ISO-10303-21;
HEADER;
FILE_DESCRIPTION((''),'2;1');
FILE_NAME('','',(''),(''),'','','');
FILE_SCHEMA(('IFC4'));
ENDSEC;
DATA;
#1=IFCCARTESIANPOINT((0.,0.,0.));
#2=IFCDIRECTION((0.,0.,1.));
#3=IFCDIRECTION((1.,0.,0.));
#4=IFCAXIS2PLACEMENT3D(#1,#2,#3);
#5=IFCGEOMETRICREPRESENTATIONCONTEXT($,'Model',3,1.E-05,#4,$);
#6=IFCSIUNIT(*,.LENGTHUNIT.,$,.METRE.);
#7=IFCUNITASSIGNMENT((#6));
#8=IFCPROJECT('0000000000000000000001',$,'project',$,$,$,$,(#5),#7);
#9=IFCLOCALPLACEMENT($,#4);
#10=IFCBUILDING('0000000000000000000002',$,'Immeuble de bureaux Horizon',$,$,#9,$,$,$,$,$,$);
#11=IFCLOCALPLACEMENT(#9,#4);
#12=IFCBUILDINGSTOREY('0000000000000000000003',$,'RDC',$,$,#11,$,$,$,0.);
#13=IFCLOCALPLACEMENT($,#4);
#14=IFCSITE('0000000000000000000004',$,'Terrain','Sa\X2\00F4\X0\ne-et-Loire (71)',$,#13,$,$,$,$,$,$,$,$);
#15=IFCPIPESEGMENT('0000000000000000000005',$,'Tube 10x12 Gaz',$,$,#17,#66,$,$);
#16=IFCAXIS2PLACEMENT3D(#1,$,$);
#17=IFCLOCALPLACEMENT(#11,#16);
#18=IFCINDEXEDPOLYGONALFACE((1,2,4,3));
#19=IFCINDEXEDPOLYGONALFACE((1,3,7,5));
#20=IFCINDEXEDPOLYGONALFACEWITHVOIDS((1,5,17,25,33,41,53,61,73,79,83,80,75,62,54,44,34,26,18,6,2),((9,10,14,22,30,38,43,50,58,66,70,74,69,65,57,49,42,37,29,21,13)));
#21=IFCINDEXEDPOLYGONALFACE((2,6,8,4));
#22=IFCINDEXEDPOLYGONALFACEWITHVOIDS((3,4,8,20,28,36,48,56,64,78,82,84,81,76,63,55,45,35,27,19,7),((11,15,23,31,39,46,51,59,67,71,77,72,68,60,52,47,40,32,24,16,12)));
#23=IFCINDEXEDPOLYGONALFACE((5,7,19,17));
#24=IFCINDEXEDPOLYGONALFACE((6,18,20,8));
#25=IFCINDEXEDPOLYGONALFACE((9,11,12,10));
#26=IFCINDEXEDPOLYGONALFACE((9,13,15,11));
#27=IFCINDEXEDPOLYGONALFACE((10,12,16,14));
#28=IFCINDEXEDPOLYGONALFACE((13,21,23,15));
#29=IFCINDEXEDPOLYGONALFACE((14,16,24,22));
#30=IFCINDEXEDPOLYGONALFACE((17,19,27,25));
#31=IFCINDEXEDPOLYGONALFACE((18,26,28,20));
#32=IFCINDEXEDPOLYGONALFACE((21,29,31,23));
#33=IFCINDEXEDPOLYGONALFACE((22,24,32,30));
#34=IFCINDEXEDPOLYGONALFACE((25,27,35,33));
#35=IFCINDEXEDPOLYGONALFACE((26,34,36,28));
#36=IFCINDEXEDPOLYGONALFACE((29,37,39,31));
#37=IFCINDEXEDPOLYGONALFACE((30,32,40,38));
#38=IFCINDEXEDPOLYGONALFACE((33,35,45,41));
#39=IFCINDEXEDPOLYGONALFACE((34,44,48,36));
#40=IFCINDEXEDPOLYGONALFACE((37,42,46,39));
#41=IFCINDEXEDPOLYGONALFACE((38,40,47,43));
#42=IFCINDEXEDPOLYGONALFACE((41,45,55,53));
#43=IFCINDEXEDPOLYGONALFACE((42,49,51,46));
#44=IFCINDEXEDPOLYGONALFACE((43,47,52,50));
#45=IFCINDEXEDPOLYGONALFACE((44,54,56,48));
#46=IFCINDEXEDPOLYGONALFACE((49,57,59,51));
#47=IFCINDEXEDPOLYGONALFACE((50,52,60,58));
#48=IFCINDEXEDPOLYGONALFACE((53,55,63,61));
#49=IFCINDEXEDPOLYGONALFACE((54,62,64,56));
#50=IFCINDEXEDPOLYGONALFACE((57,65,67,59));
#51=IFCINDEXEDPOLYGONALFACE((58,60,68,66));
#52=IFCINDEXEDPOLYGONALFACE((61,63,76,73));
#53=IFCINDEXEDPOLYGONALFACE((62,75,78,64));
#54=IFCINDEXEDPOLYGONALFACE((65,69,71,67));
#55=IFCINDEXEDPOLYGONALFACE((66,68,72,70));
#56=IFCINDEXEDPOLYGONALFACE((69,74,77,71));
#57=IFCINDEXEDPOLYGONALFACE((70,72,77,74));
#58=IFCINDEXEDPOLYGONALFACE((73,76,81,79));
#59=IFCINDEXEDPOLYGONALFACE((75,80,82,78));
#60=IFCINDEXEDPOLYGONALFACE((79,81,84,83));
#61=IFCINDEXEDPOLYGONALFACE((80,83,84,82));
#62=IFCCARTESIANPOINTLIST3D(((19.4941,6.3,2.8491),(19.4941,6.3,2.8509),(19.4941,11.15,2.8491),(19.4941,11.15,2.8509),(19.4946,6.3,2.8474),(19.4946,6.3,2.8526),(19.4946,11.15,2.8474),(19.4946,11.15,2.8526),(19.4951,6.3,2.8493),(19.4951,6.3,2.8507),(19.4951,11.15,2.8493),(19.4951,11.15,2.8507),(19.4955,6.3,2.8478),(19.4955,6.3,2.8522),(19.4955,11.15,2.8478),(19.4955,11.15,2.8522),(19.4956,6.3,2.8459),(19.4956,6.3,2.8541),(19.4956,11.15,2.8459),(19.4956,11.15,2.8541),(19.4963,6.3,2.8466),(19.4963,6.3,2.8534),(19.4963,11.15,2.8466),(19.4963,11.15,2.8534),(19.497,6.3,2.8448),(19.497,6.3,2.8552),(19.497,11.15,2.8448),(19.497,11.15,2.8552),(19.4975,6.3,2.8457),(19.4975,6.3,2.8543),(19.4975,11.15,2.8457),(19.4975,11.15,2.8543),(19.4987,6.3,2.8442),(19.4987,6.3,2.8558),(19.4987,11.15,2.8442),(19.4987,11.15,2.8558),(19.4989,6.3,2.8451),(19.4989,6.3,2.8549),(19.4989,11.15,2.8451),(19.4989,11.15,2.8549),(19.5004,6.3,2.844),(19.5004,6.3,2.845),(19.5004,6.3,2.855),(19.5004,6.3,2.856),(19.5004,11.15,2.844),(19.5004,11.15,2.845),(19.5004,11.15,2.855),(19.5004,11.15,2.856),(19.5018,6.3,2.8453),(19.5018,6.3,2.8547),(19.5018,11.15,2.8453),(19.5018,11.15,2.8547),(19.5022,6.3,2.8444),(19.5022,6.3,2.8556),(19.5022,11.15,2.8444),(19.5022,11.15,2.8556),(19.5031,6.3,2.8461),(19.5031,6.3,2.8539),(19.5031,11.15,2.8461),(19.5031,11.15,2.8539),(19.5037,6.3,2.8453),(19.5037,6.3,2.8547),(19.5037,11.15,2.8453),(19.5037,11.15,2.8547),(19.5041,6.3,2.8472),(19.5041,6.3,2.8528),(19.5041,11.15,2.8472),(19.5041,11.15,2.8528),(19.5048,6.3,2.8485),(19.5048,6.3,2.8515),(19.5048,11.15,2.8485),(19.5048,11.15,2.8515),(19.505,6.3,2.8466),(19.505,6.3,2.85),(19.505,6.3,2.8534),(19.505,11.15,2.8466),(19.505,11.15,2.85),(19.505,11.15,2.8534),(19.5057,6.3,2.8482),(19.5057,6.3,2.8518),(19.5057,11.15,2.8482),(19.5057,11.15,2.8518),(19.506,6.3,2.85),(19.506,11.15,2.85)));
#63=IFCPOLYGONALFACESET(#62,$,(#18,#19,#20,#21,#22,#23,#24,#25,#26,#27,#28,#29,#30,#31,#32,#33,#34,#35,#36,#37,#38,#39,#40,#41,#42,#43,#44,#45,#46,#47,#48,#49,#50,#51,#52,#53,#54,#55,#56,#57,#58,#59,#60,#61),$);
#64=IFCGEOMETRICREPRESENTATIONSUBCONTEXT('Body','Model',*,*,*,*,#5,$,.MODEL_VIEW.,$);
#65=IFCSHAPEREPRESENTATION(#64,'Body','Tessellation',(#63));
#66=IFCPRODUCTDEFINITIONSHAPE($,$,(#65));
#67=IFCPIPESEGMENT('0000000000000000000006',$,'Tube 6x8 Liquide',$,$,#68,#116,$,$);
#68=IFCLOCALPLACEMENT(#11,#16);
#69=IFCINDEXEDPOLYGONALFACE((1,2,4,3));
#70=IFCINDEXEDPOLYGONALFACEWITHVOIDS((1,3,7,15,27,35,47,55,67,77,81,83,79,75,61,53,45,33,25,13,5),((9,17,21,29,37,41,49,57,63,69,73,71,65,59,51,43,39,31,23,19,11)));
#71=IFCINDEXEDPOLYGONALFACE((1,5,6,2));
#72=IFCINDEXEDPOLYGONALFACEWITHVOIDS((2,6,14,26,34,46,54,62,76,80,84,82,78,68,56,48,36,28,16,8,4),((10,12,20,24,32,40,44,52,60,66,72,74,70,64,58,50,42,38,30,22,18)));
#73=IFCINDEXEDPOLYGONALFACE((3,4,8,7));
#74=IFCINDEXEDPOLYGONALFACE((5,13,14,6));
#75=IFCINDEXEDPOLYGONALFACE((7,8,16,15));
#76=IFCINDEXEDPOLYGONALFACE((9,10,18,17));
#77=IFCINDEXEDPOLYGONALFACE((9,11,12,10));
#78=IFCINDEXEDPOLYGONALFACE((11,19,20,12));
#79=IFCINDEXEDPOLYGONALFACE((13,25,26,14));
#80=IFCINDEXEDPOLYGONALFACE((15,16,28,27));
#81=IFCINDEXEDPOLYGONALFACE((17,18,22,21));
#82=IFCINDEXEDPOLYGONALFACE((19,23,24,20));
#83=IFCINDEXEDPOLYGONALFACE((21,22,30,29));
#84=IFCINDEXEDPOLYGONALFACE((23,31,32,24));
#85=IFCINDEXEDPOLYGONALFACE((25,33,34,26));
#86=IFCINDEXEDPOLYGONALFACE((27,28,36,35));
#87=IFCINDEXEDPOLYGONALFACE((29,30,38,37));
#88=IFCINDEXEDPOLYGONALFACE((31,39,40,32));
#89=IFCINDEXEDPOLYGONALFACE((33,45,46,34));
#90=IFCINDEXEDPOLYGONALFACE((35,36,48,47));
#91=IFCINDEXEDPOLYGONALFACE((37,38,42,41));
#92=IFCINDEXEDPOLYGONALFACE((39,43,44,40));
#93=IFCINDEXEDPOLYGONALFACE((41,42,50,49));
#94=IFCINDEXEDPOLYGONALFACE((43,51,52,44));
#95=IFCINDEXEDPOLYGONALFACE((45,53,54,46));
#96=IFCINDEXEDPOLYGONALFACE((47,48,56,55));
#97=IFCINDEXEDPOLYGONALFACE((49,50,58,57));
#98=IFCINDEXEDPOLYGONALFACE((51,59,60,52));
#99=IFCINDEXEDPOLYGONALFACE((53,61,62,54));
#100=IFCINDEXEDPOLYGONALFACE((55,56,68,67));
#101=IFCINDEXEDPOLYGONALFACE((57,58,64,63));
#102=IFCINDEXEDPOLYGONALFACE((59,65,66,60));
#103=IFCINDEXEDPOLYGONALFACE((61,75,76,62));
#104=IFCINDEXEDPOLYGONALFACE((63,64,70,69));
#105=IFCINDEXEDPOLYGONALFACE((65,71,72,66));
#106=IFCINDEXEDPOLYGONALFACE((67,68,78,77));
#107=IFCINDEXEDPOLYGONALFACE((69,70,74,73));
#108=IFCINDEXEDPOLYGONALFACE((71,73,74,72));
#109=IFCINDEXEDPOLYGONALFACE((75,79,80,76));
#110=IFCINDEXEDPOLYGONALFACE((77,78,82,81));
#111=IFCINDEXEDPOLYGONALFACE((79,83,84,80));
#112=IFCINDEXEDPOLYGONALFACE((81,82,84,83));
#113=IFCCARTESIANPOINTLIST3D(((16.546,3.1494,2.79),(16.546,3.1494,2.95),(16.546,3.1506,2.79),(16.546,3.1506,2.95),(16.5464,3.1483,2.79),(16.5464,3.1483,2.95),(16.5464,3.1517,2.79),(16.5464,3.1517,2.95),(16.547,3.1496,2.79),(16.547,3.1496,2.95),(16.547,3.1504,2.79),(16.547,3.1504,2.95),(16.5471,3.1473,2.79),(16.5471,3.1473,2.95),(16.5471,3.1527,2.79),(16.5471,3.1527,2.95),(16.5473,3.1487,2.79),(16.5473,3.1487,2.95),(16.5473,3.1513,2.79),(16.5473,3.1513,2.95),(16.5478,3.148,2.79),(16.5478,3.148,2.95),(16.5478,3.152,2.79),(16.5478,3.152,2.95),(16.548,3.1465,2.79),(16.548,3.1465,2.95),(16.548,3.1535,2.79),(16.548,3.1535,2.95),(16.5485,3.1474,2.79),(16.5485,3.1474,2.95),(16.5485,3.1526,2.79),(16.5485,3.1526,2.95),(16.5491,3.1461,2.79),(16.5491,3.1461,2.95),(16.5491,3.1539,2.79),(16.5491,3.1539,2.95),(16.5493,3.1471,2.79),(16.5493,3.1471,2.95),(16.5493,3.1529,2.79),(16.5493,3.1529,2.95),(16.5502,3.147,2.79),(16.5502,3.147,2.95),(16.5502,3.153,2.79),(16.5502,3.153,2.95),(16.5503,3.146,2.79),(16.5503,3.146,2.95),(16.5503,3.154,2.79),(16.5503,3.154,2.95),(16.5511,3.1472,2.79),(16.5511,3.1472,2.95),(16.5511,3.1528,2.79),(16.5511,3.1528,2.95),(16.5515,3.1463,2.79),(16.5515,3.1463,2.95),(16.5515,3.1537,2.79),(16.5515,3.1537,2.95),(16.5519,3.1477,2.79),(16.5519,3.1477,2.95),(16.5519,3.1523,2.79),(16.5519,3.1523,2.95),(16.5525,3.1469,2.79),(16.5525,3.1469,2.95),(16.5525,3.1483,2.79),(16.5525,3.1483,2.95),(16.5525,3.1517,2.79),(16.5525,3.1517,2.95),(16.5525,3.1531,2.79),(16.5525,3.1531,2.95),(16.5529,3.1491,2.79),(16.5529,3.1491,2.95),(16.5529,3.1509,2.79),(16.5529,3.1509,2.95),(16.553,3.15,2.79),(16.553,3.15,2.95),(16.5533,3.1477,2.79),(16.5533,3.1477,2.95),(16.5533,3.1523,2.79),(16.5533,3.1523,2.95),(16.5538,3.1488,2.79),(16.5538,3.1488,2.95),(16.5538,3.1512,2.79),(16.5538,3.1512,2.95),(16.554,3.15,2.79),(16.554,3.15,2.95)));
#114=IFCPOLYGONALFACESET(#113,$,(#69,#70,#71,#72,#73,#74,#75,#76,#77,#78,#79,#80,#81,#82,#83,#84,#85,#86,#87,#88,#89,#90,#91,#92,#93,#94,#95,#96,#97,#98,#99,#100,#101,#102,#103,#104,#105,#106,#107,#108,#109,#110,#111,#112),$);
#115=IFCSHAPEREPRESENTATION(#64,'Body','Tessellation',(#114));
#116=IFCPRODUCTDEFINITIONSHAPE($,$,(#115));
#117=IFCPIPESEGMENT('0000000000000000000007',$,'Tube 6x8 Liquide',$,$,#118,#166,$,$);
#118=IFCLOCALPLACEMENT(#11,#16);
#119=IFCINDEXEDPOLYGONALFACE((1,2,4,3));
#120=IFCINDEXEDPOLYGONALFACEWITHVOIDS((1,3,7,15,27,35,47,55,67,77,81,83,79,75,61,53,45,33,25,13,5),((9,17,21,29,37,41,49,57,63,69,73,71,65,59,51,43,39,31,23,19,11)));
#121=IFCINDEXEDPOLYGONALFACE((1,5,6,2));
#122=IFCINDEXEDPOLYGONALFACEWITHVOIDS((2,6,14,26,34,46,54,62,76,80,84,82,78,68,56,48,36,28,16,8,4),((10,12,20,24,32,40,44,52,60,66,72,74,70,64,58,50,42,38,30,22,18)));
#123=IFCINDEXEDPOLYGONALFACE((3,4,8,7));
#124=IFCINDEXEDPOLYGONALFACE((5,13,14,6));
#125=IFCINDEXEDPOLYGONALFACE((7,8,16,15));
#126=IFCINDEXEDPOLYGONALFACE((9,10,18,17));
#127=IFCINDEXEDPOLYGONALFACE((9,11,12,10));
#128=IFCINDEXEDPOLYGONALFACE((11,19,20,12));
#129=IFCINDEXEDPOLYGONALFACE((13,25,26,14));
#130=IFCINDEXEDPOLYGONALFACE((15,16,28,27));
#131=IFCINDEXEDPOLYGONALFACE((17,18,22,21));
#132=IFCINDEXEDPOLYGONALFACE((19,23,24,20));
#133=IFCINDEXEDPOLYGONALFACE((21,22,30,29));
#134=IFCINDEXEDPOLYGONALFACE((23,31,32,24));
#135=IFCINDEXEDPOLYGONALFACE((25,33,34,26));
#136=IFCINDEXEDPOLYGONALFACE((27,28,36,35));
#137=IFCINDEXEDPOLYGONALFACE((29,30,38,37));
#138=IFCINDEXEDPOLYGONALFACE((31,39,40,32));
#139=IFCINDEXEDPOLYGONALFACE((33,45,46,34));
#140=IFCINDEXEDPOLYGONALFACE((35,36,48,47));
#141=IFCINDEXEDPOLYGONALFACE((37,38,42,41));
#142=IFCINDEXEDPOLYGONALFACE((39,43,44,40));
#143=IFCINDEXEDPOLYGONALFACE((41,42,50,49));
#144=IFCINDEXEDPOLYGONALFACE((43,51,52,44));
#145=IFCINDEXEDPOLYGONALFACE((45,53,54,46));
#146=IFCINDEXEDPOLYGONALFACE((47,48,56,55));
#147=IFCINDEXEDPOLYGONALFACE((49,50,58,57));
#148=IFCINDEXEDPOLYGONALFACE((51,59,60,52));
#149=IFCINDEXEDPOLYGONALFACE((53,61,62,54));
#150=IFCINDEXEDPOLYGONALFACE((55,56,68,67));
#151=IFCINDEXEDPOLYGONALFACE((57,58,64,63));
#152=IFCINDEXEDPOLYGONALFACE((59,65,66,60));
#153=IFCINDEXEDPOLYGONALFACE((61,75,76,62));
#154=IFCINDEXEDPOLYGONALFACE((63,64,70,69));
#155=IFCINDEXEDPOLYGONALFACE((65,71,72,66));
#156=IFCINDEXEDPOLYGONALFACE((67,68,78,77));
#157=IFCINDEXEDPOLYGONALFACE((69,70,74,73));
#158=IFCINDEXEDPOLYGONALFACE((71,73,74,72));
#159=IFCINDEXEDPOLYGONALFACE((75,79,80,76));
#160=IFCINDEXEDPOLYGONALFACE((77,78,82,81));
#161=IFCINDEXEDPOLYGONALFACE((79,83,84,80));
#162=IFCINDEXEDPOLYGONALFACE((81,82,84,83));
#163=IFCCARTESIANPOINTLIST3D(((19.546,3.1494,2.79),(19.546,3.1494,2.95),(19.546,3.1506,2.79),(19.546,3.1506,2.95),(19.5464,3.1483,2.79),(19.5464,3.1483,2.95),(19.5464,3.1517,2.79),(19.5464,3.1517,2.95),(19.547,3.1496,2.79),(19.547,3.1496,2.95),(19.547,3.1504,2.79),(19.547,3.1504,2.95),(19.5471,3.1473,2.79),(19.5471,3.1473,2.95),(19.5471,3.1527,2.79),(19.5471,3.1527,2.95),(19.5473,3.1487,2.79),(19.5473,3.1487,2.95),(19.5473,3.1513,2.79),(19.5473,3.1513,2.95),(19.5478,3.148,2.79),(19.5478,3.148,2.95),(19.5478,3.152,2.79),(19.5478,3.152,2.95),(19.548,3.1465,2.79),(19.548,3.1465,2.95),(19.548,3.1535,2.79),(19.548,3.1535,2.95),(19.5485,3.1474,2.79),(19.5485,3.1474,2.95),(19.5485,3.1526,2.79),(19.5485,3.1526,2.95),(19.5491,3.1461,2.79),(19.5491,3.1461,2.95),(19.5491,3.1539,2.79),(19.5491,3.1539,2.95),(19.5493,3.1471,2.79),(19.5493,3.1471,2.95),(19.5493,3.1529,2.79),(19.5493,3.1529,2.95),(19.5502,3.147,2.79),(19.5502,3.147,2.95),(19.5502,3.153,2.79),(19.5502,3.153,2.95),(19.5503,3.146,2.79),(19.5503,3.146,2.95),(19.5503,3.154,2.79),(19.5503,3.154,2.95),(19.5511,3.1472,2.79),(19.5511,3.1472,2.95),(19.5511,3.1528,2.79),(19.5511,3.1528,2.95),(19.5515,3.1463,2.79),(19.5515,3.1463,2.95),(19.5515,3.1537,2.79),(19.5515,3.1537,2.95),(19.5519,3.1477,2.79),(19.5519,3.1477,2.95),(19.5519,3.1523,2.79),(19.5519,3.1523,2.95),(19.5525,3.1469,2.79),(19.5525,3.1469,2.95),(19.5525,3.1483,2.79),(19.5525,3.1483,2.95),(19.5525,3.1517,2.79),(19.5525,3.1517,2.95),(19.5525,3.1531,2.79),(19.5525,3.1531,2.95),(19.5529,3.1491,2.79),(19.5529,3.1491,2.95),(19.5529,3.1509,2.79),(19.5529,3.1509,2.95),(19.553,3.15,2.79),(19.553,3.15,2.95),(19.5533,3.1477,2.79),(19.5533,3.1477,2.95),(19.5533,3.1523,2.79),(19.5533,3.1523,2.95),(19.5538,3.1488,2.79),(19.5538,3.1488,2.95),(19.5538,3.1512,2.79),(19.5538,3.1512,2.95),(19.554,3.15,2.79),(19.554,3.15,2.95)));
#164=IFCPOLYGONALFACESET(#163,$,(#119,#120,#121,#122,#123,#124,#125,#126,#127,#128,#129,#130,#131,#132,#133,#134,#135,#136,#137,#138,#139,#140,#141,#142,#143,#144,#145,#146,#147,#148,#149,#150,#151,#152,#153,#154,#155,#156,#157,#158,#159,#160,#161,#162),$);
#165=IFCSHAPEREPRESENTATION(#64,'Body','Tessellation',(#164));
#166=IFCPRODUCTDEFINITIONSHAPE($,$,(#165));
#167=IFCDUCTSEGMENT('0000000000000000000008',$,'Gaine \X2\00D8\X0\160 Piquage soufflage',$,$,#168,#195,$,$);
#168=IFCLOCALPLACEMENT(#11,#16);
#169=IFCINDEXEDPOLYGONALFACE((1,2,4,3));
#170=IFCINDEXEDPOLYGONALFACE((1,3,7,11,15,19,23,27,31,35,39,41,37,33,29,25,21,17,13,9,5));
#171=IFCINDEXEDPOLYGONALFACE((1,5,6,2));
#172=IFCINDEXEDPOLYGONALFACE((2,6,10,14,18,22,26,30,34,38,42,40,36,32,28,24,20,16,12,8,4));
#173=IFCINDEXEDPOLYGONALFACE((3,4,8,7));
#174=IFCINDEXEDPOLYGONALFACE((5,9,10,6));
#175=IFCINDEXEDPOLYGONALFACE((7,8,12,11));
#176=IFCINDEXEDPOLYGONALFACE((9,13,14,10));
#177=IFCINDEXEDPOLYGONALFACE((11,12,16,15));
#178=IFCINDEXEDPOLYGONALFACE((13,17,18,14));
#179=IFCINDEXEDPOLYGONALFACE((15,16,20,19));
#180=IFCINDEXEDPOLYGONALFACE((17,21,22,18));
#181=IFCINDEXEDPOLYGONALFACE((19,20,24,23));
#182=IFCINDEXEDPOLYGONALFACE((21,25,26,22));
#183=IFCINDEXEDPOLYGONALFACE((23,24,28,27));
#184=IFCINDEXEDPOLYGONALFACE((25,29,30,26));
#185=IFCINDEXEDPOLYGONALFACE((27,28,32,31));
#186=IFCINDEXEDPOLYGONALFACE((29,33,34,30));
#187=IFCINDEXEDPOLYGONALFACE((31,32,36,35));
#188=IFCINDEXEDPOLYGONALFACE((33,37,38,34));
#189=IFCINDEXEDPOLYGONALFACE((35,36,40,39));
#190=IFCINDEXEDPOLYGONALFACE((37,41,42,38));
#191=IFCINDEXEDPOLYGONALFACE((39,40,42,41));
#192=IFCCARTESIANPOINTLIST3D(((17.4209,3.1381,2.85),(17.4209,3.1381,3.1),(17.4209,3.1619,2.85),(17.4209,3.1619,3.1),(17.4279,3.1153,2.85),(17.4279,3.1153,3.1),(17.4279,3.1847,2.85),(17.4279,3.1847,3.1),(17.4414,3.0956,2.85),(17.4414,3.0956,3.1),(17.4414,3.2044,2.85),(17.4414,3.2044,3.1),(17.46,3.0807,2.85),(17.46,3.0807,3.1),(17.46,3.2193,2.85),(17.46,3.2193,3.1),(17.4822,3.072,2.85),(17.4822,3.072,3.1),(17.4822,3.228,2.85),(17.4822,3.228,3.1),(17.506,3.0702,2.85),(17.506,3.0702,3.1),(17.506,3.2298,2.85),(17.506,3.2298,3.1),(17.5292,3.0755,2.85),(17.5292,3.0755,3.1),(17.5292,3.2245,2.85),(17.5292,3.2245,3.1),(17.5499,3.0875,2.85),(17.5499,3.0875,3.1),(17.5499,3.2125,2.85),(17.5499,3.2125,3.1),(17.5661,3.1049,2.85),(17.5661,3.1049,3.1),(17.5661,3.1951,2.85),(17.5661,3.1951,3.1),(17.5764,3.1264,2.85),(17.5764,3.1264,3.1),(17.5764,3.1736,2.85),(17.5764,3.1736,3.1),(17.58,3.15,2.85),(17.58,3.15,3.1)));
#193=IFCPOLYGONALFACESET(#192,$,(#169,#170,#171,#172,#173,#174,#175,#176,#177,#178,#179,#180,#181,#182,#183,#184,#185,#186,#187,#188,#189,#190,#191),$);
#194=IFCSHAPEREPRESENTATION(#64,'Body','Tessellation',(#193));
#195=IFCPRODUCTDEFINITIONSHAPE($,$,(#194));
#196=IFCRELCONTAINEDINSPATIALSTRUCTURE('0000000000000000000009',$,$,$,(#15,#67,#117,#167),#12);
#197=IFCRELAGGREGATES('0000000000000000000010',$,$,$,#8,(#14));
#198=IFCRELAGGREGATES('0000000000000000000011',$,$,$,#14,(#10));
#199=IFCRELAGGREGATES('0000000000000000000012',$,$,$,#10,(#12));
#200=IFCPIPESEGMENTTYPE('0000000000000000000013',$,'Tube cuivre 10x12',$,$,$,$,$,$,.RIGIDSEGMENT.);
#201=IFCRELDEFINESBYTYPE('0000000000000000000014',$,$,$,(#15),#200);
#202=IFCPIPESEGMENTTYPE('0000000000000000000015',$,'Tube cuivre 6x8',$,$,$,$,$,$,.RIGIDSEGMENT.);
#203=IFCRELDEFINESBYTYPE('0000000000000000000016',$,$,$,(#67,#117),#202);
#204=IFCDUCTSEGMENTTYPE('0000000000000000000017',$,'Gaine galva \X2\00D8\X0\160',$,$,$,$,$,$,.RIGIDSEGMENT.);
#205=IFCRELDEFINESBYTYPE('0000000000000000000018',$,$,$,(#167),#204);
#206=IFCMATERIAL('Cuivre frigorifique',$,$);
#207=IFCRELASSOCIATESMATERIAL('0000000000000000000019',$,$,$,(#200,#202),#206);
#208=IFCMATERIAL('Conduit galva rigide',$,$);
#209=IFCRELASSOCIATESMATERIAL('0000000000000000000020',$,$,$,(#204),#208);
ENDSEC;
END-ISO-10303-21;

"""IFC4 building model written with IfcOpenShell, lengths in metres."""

from ifc_helpers import new_model, si_unit, frame, origin_with_axes, place, context, subcontext, project, spatial, circle, hollow_circle, extrude, material, type_object, element, save


model = new_model("IFC4")

# Units and contexts
model_context = context("Model", 3, precision=1e-05, world=origin_with_axes())
body_context = subcontext(model_context, "Body", "Model", "MODEL_VIEW")
ifc_project = project(units=[si_unit("LENGTHUNIT", "METRE")], contexts=[model_context])

# Site, building, storey
site_placement = place(None, origin_with_axes())
site = spatial("IfcSite", under=ifc_project, at=site_placement, Name="Terrain", Description="Saône-et-Loire (71)")
building_placement = place(None, origin_with_axes())
building = spatial("IfcBuilding", under=site, at=building_placement, Name="Immeuble de bureaux Horizon")
storey_placement = place(building_placement, origin_with_axes())
storey = spatial("IfcBuildingStorey", under=building, at=storey_placement, Name="RDC", Elevation=0.0)

# Pipe segments
ifc_material_1 = material(Name="Cuivre frigorifique")
pipe_segment_type_1 = type_object("IfcPipeSegmentType", Name="Tube cuivre 10x12", PredefinedType="RIGIDSEGMENT", material=ifc_material_1)
for number, where, z_axis, x_axis, name in (
    (1, (19.5, 6.3, 2.85), (0.0, 1.0, 0.0), (1.0, 0.0, 0.0), "Tube 10x12 Gaz"),
):
    element("IfcPipeSegment", number, at=place(storey_placement, frame(where, z_axis=z_axis, x_axis=x_axis)), inside=storey, type_object=pipe_segment_type_1, Name=name, context=body_context, shape_type="SweptSolid", body=[
        extrude(hollow_circle(Radius=0.006, WallThickness=0.001), origin_with_axes(), (0.0, 0.0, 1.0), 4.85),
    ])
pipe_segment_type_2 = type_object("IfcPipeSegmentType", Name="Tube cuivre 6x8", PredefinedType="RIGIDSEGMENT", material=ifc_material_1)
for number, where, z_axis, x_axis, name in (
    (2, (16.55, 3.15, 2.79), (0.0, 0.0, 1.0), (1.0, 0.0, 0.0), "Tube 6x8 Liquide"),
    (3, (19.55, 3.15, 2.79), (0.0, 0.0, 1.0), (1.0, 0.0, 0.0), "Tube 6x8 Liquide"),
):
    element("IfcPipeSegment", number, at=place(storey_placement, frame(where, z_axis=z_axis, x_axis=x_axis)), inside=storey, type_object=pipe_segment_type_2, Name=name, context=body_context, shape_type="SweptSolid", body=[
        extrude(hollow_circle(Radius=0.004, WallThickness=0.001), origin_with_axes(), (0.0, 0.0, 1.0), 0.16),
    ])

# Duct segment
ifc_material_2 = material(Name="Conduit galva rigide")
duct_segment_type = type_object("IfcDuctSegmentType", Name="Gaine galva Ø160", PredefinedType="RIGIDSEGMENT", material=ifc_material_2)
duct_segment_1_placement = place(storey_placement, frame((17.5, 3.15, 3.1), z_axis=(0.0, 0.0, -1.0), x_axis=(1.0, 0.0, 0.0)))
element("IfcDuctSegment", 4, at=duct_segment_1_placement, inside=storey, type_object=duct_segment_type, Name="Gaine Ø160 Piquage soufflage", context=body_context, shape_type="SweptSolid", body=[
    extrude(circle(Radius=0.08), origin_with_axes(), (0.0, 0.0, 1.0), 0.25),
])

save(model, "model.ifc")
